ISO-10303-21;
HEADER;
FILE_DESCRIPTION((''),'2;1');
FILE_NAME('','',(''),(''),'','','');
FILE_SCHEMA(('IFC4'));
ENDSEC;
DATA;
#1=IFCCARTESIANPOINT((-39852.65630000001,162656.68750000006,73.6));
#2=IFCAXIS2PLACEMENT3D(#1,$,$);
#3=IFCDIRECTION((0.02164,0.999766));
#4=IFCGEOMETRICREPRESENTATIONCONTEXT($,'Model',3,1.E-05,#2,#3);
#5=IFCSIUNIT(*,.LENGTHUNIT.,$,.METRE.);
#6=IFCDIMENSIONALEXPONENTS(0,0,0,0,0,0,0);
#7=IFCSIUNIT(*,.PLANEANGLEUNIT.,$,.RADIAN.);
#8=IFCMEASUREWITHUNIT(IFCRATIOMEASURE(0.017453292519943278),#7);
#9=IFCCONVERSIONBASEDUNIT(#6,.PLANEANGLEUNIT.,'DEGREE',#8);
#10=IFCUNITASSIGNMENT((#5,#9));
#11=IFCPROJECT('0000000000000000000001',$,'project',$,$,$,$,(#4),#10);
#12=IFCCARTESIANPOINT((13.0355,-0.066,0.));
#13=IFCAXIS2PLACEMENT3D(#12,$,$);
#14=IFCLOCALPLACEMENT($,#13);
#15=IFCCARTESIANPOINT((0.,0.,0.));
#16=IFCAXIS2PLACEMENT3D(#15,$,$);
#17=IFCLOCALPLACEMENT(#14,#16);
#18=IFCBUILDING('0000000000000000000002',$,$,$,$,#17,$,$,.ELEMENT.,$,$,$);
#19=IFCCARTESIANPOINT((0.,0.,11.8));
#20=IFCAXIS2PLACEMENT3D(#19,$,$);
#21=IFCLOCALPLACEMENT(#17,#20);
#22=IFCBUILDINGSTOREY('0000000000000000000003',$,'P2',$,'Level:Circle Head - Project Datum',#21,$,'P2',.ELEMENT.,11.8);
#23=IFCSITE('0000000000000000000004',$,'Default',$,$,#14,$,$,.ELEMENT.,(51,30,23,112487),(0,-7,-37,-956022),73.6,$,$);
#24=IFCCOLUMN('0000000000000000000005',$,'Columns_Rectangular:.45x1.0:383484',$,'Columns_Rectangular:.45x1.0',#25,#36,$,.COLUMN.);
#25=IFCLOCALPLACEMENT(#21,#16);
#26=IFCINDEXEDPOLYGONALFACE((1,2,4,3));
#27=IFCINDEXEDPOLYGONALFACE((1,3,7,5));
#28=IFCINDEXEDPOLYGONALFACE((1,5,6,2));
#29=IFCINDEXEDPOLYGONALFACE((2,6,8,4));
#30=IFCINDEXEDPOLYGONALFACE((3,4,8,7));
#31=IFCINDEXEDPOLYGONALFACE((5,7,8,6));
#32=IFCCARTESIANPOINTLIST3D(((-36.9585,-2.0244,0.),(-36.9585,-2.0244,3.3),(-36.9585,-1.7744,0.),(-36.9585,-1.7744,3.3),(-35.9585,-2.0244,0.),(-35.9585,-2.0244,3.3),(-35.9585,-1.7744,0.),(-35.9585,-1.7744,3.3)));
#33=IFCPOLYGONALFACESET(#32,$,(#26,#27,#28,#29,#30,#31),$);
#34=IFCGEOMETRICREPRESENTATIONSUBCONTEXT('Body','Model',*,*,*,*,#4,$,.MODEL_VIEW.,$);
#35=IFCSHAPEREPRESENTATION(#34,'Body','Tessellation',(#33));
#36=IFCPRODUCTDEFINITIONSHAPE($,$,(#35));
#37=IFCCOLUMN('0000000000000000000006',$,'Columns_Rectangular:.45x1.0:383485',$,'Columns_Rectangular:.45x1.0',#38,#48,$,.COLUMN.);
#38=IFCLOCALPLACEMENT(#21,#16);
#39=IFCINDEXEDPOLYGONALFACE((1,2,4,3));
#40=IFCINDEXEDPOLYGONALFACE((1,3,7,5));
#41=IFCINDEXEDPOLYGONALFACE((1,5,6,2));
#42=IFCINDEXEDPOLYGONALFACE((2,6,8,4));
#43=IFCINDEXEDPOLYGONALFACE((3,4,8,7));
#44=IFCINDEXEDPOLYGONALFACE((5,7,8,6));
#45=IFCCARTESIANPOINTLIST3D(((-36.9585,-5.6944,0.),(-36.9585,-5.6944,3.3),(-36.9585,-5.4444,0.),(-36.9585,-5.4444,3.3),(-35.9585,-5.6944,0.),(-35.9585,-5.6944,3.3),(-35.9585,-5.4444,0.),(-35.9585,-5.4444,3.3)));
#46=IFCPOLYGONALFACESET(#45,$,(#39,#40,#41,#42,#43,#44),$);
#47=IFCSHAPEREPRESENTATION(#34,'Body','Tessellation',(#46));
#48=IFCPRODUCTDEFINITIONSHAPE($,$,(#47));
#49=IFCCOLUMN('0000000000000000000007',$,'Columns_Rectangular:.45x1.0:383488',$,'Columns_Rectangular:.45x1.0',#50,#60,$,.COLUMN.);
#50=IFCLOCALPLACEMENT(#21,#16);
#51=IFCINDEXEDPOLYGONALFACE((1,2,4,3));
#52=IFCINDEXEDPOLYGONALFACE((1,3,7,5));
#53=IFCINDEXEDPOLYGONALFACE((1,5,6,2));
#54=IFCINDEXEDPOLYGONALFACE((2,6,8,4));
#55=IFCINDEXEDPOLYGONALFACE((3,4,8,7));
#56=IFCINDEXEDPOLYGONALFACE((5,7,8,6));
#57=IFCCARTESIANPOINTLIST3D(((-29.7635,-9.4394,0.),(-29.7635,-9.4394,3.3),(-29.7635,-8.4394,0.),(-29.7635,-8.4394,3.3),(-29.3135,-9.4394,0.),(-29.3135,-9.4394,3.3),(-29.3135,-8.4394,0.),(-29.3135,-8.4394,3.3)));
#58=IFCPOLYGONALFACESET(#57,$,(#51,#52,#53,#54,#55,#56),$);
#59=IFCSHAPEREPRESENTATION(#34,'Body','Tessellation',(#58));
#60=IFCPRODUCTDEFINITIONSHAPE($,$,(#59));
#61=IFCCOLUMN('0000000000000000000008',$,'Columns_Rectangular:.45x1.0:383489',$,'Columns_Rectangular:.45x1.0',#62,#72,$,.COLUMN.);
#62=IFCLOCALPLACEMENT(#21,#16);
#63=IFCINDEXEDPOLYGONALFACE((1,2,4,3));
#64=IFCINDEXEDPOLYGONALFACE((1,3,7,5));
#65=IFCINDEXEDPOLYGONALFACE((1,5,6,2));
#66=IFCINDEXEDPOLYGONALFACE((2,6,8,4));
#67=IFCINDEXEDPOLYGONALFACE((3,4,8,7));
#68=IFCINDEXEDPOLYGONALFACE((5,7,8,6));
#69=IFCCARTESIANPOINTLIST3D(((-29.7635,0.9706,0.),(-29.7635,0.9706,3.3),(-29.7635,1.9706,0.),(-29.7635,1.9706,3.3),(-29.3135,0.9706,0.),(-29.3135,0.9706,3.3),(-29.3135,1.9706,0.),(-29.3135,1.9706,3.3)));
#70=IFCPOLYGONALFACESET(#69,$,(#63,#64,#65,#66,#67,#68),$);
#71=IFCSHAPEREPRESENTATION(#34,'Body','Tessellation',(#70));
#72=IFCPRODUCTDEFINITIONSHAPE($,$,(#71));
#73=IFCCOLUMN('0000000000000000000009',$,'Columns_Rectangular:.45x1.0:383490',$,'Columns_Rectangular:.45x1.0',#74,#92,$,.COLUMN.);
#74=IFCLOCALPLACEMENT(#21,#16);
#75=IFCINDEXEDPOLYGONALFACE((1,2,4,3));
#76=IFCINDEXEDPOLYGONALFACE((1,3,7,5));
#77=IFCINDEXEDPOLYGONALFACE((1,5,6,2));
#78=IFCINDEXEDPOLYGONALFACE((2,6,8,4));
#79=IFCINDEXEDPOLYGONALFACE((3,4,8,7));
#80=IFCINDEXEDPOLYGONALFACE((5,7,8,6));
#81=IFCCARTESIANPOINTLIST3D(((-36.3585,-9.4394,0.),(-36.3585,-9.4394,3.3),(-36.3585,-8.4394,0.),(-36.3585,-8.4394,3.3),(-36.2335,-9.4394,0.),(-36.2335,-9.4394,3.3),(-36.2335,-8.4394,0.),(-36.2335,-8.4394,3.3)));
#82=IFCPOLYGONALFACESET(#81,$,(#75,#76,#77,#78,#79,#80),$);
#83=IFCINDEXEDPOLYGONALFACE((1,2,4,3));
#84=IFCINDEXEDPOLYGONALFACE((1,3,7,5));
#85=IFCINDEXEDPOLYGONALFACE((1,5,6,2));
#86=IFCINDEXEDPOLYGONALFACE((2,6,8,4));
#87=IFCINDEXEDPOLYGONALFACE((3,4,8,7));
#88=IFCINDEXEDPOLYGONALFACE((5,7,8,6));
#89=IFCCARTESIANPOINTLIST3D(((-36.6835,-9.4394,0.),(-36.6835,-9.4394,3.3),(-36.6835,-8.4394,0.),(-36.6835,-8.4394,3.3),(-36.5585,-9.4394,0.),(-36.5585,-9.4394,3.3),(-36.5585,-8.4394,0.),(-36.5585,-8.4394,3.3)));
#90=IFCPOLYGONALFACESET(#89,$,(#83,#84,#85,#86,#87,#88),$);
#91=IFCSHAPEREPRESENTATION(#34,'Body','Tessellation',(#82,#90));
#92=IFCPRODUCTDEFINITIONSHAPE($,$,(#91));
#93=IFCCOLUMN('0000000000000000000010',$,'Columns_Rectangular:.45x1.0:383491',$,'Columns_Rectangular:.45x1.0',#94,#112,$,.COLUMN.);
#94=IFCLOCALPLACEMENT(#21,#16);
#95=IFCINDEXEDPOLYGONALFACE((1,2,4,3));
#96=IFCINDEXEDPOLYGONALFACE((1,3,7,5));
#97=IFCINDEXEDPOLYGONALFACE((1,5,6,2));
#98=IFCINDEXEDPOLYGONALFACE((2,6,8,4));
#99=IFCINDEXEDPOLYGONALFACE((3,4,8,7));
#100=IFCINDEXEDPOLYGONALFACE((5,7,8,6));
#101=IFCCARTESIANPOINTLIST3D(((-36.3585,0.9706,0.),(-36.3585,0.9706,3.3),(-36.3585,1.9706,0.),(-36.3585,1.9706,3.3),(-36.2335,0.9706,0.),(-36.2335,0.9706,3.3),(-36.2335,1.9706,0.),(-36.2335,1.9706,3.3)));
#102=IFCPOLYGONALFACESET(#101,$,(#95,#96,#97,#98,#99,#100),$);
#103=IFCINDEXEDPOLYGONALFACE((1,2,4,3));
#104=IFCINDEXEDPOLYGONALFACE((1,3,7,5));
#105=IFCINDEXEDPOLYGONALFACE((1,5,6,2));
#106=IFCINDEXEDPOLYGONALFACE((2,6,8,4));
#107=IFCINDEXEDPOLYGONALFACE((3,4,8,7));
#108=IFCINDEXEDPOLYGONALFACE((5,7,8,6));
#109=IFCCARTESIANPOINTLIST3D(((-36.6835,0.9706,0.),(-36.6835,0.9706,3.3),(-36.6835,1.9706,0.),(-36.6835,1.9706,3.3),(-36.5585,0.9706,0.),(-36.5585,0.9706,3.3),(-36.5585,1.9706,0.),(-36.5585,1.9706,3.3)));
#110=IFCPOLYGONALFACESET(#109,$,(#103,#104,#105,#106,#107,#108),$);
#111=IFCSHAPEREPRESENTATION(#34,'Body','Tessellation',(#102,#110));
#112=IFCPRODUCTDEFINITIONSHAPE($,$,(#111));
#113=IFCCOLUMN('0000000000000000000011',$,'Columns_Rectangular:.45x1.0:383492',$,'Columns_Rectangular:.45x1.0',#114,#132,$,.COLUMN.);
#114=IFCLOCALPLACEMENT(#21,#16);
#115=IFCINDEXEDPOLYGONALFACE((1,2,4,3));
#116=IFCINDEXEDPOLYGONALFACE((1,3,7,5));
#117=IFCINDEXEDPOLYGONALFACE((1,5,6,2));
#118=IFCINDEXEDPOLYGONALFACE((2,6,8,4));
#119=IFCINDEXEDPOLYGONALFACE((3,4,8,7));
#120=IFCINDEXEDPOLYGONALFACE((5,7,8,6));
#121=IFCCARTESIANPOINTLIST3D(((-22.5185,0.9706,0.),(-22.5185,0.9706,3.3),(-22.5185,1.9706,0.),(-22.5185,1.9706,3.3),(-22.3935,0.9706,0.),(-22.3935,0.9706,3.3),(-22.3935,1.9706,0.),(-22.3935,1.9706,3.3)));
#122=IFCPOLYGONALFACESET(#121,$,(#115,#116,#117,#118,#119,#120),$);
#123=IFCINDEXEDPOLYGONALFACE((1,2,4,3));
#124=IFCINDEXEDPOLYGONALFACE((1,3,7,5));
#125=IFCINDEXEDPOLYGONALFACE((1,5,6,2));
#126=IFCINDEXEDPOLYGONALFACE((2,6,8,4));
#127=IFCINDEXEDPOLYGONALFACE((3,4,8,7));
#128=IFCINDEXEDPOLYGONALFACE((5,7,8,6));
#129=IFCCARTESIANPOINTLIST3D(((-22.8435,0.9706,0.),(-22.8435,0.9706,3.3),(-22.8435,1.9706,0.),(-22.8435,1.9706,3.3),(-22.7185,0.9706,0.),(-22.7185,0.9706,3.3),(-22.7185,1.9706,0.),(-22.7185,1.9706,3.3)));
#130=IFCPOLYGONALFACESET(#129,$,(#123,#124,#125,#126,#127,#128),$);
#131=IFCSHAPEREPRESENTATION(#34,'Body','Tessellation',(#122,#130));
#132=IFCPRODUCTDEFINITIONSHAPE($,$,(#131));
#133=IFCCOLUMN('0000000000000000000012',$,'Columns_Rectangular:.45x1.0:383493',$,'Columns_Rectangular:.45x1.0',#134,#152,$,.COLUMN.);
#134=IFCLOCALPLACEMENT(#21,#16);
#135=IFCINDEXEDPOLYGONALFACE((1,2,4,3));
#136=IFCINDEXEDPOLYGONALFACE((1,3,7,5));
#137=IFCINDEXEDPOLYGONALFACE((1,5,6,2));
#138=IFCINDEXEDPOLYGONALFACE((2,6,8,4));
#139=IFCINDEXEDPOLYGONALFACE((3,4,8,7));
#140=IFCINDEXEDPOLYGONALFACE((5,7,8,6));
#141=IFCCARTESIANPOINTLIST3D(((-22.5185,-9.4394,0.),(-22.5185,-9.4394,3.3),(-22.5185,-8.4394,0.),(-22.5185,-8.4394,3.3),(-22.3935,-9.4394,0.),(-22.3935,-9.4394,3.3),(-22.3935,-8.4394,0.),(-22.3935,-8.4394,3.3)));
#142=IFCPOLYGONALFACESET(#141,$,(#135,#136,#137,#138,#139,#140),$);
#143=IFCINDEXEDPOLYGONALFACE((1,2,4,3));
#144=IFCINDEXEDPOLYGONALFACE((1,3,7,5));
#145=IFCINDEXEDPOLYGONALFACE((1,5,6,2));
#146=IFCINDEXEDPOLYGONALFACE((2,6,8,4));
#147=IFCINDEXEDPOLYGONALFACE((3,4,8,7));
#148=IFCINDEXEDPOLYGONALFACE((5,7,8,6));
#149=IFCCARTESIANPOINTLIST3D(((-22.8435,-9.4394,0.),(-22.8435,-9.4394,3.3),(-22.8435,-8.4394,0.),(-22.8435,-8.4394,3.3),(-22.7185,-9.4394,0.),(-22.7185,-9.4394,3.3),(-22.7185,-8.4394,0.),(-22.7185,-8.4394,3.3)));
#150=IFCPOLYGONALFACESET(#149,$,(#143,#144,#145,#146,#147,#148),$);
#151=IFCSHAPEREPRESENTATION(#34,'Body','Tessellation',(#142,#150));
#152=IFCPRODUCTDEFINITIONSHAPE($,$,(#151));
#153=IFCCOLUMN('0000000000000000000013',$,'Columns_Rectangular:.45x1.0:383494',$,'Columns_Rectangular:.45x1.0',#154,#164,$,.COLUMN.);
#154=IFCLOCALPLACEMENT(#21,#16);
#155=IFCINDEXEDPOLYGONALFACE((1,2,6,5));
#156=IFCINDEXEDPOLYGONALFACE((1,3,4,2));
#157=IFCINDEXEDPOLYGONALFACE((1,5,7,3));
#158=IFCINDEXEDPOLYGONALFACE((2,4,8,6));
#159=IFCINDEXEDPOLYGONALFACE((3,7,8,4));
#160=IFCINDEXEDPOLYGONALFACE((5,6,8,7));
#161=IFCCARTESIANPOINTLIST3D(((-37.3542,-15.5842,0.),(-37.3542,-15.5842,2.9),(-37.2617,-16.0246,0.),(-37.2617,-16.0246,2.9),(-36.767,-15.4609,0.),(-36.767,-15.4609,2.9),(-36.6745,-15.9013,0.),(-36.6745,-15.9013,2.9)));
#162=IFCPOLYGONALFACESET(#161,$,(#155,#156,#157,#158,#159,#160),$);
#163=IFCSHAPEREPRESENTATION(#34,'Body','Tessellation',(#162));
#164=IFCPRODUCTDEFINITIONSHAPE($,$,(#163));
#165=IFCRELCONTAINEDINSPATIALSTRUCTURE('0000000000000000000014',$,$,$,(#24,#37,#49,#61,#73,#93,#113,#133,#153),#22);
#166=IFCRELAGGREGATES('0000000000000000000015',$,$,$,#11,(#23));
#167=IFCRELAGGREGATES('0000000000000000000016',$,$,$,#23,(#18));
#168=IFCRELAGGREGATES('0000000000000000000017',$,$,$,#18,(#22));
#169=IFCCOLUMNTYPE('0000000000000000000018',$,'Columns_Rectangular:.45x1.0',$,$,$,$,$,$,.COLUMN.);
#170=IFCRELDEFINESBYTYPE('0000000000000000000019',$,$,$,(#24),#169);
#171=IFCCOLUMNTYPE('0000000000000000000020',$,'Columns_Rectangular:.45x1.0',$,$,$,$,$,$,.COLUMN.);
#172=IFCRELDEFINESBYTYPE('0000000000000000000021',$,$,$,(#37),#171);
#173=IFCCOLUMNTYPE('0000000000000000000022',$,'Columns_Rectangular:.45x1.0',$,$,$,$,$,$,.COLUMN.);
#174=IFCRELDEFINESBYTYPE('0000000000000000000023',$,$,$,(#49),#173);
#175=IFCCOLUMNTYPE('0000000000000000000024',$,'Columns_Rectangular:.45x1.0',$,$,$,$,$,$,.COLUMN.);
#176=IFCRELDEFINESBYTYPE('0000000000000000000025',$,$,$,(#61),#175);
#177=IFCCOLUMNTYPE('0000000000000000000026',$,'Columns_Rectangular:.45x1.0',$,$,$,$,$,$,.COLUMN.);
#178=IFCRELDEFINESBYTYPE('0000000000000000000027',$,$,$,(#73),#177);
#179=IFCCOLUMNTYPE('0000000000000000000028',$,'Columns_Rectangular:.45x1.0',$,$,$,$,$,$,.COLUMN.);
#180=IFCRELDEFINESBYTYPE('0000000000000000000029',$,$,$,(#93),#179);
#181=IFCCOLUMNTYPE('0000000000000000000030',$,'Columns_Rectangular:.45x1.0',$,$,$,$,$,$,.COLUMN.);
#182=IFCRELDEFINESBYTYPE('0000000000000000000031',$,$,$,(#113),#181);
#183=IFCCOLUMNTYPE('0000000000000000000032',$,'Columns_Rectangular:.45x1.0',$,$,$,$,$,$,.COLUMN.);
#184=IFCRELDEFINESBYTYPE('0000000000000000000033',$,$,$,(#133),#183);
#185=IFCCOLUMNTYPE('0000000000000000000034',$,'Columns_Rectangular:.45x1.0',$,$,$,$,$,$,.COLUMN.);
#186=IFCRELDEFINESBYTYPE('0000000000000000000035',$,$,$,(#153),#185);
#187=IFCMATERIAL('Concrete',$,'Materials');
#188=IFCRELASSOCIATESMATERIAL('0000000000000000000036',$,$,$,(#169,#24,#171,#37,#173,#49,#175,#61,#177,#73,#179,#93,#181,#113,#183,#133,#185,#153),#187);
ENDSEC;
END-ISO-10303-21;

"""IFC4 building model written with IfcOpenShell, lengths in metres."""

from ifc_helpers import new_model, entity, si_unit, converted_unit, direction, frame, origin, place, context, subcontext, project, spatial, indexed_curve, outline, extrude, source, transform, mapped, material, type_object, type_shapes, element, save


model = new_model("IFC4")

# Units and contexts
model_context = context("Model", 3, precision=1e-05, world=frame((-39852.65630000001, 162656.68750000006, 73.6)), true_north=direction((0.02164, 0.999766)))
body_context = subcontext(model_context, "Body", "Model", "MODEL_VIEW")
ifc_project = project(units=[si_unit("LENGTHUNIT", "METRE"), converted_unit("PLANEANGLEUNIT", "DEGREE", entity("IfcRatioMeasure", 0.017453292519943278), si_unit("PLANEANGLEUNIT", "RADIAN"), dimensions=[0, 0, 0, 0, 0, 0, 0])], contexts=[model_context])

# Site, building, storey
site_placement = place(None, frame((13.0355, -0.066, 0.0)))
site = spatial("IfcSite", under=ifc_project, at=site_placement, Name="Default", CompositionType="ELEMENT", RefLatitude=(51, 30, 23, 112487), RefLongitude=(0, -7, -37, -956022), RefElevation=73.6)
building_placement = place(site_placement, origin())
building = spatial("IfcBuilding", under=site, at=building_placement, CompositionType="ELEMENT")
storey_placement = place(building_placement, frame((0.0, 0.0, 11.8)))
storey = spatial("IfcBuildingStorey", under=building, at=storey_placement, Name="P2", ObjectType="Level:Circle Head - Project Datum", LongName="P2", CompositionType="ELEMENT", Elevation=11.8)

# Columns
ifc_material = material(Name="Concrete", Category="Materials")
column_type_1 = type_object("IfcColumnType", Name="Columns_Rectangular:.45x1.0", PredefinedType="COLUMN", material=ifc_material)
shared_shape_1 = source(origin(), body_context, "Body", "SweptSolid", [
    extrude(outline(indexed_curve([(-0.125, -0.5), (0.125, -0.5), (0.125, 0.5), (-0.125, 0.5), (-0.125, -0.5)], self_intersect=False)), frame((-36.4585, -1.8994, 11.8), z_axis=(0.0, 0.0, 1.0), x_axis=(0.0, -1.0, 0.0)), (0.0, 0.0, 1.0), 3.3),
])
type_shapes(column_type_1, [shared_shape_1])
column_1_placement = place(storey_placement, frame((0.0, 0.0, -11.8)))
element("IfcColumn", 1, at=column_1_placement, inside=storey, type_object=column_type_1, material=ifc_material, Name="Columns_Rectangular:.45x1.0:383484", ObjectType="Columns_Rectangular:.45x1.0", PredefinedType="COLUMN", context=body_context, shape_type="MappedRepresentation", body=[
    mapped(shared_shape_1, transform((0.0, 0.0, 0.0), scale=1.0)),
])
column_type_2 = type_object("IfcColumnType", Name="Columns_Rectangular:.45x1.0", PredefinedType="COLUMN", material=ifc_material)
shared_shape_2 = source(origin(), body_context, "Body", "SweptSolid", [
    extrude(outline(indexed_curve([(-0.125, -0.5), (0.125, -0.5), (0.125, 0.5), (-0.125, 0.5), (-0.125, -0.5)], self_intersect=False)), frame((-36.4585, -5.5694, 11.8), z_axis=(0.0, 0.0, 1.0), x_axis=(0.0, -1.0, 0.0)), (0.0, 0.0, 1.0), 3.3),
])
type_shapes(column_type_2, [shared_shape_2])
column_2_placement = place(storey_placement, frame((0.0, 0.0, -11.8)))
element("IfcColumn", 2, at=column_2_placement, inside=storey, type_object=column_type_2, material=ifc_material, Name="Columns_Rectangular:.45x1.0:383485", ObjectType="Columns_Rectangular:.45x1.0", PredefinedType="COLUMN", context=body_context, shape_type="MappedRepresentation", body=[
    mapped(shared_shape_2, transform((0.0, 0.0, 0.0), scale=1.0)),
])
column_type_3 = type_object("IfcColumnType", Name="Columns_Rectangular:.45x1.0", PredefinedType="COLUMN", material=ifc_material)
shared_shape_3 = source(origin(), body_context, "Body", "SweptSolid", [
    extrude(outline(indexed_curve([(-0.5, -0.225), (0.5, -0.225), (0.5, 0.225), (-0.5, 0.225), (-0.5, -0.225)], self_intersect=False)), frame((-29.5385, -8.9394, 11.8), z_axis=(0.0, 0.0, 1.0), x_axis=(0.0, -1.0, 0.0)), (0.0, 0.0, 1.0), 3.3),
])
type_shapes(column_type_3, [shared_shape_3])
column_3_placement = place(storey_placement, frame((0.0, 0.0, -11.8)))
element("IfcColumn", 3, at=column_3_placement, inside=storey, type_object=column_type_3, material=ifc_material, Name="Columns_Rectangular:.45x1.0:383488", ObjectType="Columns_Rectangular:.45x1.0", PredefinedType="COLUMN", context=body_context, shape_type="MappedRepresentation", body=[
    mapped(shared_shape_3, transform((0.0, 0.0, 0.0), scale=1.0)),
])
column_type_4 = type_object("IfcColumnType", Name="Columns_Rectangular:.45x1.0", PredefinedType="COLUMN", material=ifc_material)
shared_shape_4 = source(origin(), body_context, "Body", "SweptSolid", [
    extrude(outline(indexed_curve([(-0.5, -0.225), (0.5, -0.225), (0.5, 0.225), (-0.5, 0.225), (-0.5, -0.225)], self_intersect=False)), frame((-29.5385, 1.4706, 11.8), z_axis=(0.0, 0.0, 1.0), x_axis=(0.0, -1.0, 0.0)), (0.0, 0.0, 1.0), 3.3),
])
type_shapes(column_type_4, [shared_shape_4])
column_4_placement = place(storey_placement, frame((0.0, 0.0, -11.8)))
element("IfcColumn", 4, at=column_4_placement, inside=storey, type_object=column_type_4, material=ifc_material, Name="Columns_Rectangular:.45x1.0:383489", ObjectType="Columns_Rectangular:.45x1.0", PredefinedType="COLUMN", context=body_context, shape_type="MappedRepresentation", body=[
    mapped(shared_shape_4, transform((0.0, 0.0, 0.0), scale=1.0)),
])
column_type_5 = type_object("IfcColumnType", Name="Columns_Rectangular:.45x1.0", PredefinedType="COLUMN", material=ifc_material)
shared_shape_5 = source(origin(), body_context, "Body", "SweptSolid", [
    extrude(outline(indexed_curve([(-0.5, -0.0625), (0.5, -0.0625), (0.5, 0.0625), (-0.5, 0.0625), (-0.5, -0.0625)], self_intersect=False)), frame((-36.296, -8.9394, 11.8), z_axis=(0.0, 0.0, 1.0), x_axis=(0.0, -1.0, 0.0)), (0.0, 0.0, 1.0), 3.3),
    extrude(outline(indexed_curve([(-0.5, -0.0625), (0.5, -0.0625), (0.5, 0.0625), (-0.5, 0.0625), (-0.5, -0.0625)], self_intersect=False)), frame((-36.621, -8.9394, 11.8), z_axis=(0.0, 0.0, 1.0), x_axis=(0.0, -1.0, 0.0)), (0.0, 0.0, 1.0), 3.3),
])
type_shapes(column_type_5, [shared_shape_5])
column_5_placement = place(storey_placement, frame((0.0, 0.0, -11.8)))
element("IfcColumn", 5, at=column_5_placement, inside=storey, type_object=column_type_5, material=ifc_material, Name="Columns_Rectangular:.45x1.0:383490", ObjectType="Columns_Rectangular:.45x1.0", PredefinedType="COLUMN", context=body_context, shape_type="MappedRepresentation", body=[
    mapped(shared_shape_5, transform((0.0, 0.0, 0.0), scale=1.0)),
])
column_type_6 = type_object("IfcColumnType", Name="Columns_Rectangular:.45x1.0", PredefinedType="COLUMN", material=ifc_material)
shared_shape_6 = source(origin(), body_context, "Body", "SweptSolid", [
    extrude(outline(indexed_curve([(-0.5, -0.0625), (0.5, -0.0625), (0.5, 0.0625), (-0.5, 0.0625), (-0.5, -0.0625)], self_intersect=False)), frame((-36.296, 1.4706, 11.8), z_axis=(0.0, 0.0, 1.0), x_axis=(0.0, -1.0, 0.0)), (0.0, 0.0, 1.0), 3.3),
    extrude(outline(indexed_curve([(-0.5, -0.0625), (0.5, -0.0625), (0.5, 0.0625), (-0.5, 0.0625), (-0.5, -0.0625)], self_intersect=False)), frame((-36.621, 1.4706, 11.8), z_axis=(0.0, 0.0, 1.0), x_axis=(0.0, -1.0, 0.0)), (0.0, 0.0, 1.0), 3.3),
])
type_shapes(column_type_6, [shared_shape_6])
column_6_placement = place(storey_placement, frame((0.0, 0.0, -11.8)))
element("IfcColumn", 6, at=column_6_placement, inside=storey, type_object=column_type_6, material=ifc_material, Name="Columns_Rectangular:.45x1.0:383491", ObjectType="Columns_Rectangular:.45x1.0", PredefinedType="COLUMN", context=body_context, shape_type="MappedRepresentation", body=[
    mapped(shared_shape_6, transform((0.0, 0.0, 0.0), scale=1.0)),
])
column_type_7 = type_object("IfcColumnType", Name="Columns_Rectangular:.45x1.0", PredefinedType="COLUMN", material=ifc_material)
shared_shape_7 = source(origin(), body_context, "Body", "SweptSolid", [
    extrude(outline(indexed_curve([(-0.5, -0.0625), (0.5, -0.0625), (0.5, 0.0625), (-0.5, 0.0625), (-0.5, -0.0625)], self_intersect=False)), frame((-22.456, 1.4706, 11.8), z_axis=(0.0, 0.0, 1.0), x_axis=(0.0, -1.0, 0.0)), (0.0, 0.0, 1.0), 3.3),
    extrude(outline(indexed_curve([(-0.5, -0.0625), (0.5, -0.0625), (0.5, 0.0625), (-0.5, 0.0625), (-0.5, -0.0625)], self_intersect=False)), frame((-22.781, 1.4706, 11.8), z_axis=(0.0, 0.0, 1.0), x_axis=(0.0, -1.0, 0.0)), (0.0, 0.0, 1.0), 3.3),
])
type_shapes(column_type_7, [shared_shape_7])
column_7_placement = place(storey_placement, frame((0.0, 0.0, -11.8)))
element("IfcColumn", 7, at=column_7_placement, inside=storey, type_object=column_type_7, material=ifc_material, Name="Columns_Rectangular:.45x1.0:383492", ObjectType="Columns_Rectangular:.45x1.0", PredefinedType="COLUMN", context=body_context, shape_type="MappedRepresentation", body=[
    mapped(shared_shape_7, transform((0.0, 0.0, 0.0), scale=1.0)),
])
column_type_8 = type_object("IfcColumnType", Name="Columns_Rectangular:.45x1.0", PredefinedType="COLUMN", material=ifc_material)
shared_shape_8 = source(origin(), body_context, "Body", "SweptSolid", [
    extrude(outline(indexed_curve([(-0.5, -0.0625), (0.5, -0.0625), (0.5, 0.0625), (-0.5, 0.0625), (-0.5, -0.0625)], self_intersect=False)), frame((-22.456, -8.9394, 11.8), z_axis=(0.0, 0.0, 1.0), x_axis=(0.0, -1.0, 0.0)), (0.0, 0.0, 1.0), 3.3),
    extrude(outline(indexed_curve([(-0.5, -0.0625), (0.5, -0.0625), (0.5, 0.0625), (-0.5, 0.0625), (-0.5, -0.0625)], self_intersect=False)), frame((-22.781, -8.9394, 11.8), z_axis=(0.0, 0.0, 1.0), x_axis=(0.0, -1.0, 0.0)), (0.0, 0.0, 1.0), 3.3),
])
type_shapes(column_type_8, [shared_shape_8])
column_8_placement = place(storey_placement, frame((0.0, 0.0, -11.8)))
element("IfcColumn", 8, at=column_8_placement, inside=storey, type_object=column_type_8, material=ifc_material, Name="Columns_Rectangular:.45x1.0:383493", ObjectType="Columns_Rectangular:.45x1.0", PredefinedType="COLUMN", context=body_context, shape_type="MappedRepresentation", body=[
    mapped(shared_shape_8, transform((0.0, 0.0, 0.0), scale=1.0)),
])
column_type_9 = type_object("IfcColumnType", Name="Columns_Rectangular:.45x1.0", PredefinedType="COLUMN", material=ifc_material)
shared_shape_9 = source(origin(), body_context, "Body", "SweptSolid", [
    extrude(outline(indexed_curve([(-0.3, -0.225), (0.3, -0.225), (0.3, 0.225), (-0.3, 0.225), (-0.3, -0.225)], self_intersect=False)), frame((-37.0144, -15.7427, 11.8), z_axis=(0.0, 0.0, 1.0), x_axis=(-0.978657, -0.2055, 0.0)), (0.0, 0.0, 1.0), 2.9),
])
type_shapes(column_type_9, [shared_shape_9])
column_9_placement = place(storey_placement, frame((0.0, 0.0, -11.8)))
element("IfcColumn", 9, at=column_9_placement, inside=storey, type_object=column_type_9, material=ifc_material, Name="Columns_Rectangular:.45x1.0:383494", ObjectType="Columns_Rectangular:.45x1.0", PredefinedType="COLUMN", context=body_context, shape_type="MappedRepresentation", body=[
    mapped(shared_shape_9, transform((0.0, 0.0, 0.0), scale=1.0)),
])

save(model, "model.ifc")
